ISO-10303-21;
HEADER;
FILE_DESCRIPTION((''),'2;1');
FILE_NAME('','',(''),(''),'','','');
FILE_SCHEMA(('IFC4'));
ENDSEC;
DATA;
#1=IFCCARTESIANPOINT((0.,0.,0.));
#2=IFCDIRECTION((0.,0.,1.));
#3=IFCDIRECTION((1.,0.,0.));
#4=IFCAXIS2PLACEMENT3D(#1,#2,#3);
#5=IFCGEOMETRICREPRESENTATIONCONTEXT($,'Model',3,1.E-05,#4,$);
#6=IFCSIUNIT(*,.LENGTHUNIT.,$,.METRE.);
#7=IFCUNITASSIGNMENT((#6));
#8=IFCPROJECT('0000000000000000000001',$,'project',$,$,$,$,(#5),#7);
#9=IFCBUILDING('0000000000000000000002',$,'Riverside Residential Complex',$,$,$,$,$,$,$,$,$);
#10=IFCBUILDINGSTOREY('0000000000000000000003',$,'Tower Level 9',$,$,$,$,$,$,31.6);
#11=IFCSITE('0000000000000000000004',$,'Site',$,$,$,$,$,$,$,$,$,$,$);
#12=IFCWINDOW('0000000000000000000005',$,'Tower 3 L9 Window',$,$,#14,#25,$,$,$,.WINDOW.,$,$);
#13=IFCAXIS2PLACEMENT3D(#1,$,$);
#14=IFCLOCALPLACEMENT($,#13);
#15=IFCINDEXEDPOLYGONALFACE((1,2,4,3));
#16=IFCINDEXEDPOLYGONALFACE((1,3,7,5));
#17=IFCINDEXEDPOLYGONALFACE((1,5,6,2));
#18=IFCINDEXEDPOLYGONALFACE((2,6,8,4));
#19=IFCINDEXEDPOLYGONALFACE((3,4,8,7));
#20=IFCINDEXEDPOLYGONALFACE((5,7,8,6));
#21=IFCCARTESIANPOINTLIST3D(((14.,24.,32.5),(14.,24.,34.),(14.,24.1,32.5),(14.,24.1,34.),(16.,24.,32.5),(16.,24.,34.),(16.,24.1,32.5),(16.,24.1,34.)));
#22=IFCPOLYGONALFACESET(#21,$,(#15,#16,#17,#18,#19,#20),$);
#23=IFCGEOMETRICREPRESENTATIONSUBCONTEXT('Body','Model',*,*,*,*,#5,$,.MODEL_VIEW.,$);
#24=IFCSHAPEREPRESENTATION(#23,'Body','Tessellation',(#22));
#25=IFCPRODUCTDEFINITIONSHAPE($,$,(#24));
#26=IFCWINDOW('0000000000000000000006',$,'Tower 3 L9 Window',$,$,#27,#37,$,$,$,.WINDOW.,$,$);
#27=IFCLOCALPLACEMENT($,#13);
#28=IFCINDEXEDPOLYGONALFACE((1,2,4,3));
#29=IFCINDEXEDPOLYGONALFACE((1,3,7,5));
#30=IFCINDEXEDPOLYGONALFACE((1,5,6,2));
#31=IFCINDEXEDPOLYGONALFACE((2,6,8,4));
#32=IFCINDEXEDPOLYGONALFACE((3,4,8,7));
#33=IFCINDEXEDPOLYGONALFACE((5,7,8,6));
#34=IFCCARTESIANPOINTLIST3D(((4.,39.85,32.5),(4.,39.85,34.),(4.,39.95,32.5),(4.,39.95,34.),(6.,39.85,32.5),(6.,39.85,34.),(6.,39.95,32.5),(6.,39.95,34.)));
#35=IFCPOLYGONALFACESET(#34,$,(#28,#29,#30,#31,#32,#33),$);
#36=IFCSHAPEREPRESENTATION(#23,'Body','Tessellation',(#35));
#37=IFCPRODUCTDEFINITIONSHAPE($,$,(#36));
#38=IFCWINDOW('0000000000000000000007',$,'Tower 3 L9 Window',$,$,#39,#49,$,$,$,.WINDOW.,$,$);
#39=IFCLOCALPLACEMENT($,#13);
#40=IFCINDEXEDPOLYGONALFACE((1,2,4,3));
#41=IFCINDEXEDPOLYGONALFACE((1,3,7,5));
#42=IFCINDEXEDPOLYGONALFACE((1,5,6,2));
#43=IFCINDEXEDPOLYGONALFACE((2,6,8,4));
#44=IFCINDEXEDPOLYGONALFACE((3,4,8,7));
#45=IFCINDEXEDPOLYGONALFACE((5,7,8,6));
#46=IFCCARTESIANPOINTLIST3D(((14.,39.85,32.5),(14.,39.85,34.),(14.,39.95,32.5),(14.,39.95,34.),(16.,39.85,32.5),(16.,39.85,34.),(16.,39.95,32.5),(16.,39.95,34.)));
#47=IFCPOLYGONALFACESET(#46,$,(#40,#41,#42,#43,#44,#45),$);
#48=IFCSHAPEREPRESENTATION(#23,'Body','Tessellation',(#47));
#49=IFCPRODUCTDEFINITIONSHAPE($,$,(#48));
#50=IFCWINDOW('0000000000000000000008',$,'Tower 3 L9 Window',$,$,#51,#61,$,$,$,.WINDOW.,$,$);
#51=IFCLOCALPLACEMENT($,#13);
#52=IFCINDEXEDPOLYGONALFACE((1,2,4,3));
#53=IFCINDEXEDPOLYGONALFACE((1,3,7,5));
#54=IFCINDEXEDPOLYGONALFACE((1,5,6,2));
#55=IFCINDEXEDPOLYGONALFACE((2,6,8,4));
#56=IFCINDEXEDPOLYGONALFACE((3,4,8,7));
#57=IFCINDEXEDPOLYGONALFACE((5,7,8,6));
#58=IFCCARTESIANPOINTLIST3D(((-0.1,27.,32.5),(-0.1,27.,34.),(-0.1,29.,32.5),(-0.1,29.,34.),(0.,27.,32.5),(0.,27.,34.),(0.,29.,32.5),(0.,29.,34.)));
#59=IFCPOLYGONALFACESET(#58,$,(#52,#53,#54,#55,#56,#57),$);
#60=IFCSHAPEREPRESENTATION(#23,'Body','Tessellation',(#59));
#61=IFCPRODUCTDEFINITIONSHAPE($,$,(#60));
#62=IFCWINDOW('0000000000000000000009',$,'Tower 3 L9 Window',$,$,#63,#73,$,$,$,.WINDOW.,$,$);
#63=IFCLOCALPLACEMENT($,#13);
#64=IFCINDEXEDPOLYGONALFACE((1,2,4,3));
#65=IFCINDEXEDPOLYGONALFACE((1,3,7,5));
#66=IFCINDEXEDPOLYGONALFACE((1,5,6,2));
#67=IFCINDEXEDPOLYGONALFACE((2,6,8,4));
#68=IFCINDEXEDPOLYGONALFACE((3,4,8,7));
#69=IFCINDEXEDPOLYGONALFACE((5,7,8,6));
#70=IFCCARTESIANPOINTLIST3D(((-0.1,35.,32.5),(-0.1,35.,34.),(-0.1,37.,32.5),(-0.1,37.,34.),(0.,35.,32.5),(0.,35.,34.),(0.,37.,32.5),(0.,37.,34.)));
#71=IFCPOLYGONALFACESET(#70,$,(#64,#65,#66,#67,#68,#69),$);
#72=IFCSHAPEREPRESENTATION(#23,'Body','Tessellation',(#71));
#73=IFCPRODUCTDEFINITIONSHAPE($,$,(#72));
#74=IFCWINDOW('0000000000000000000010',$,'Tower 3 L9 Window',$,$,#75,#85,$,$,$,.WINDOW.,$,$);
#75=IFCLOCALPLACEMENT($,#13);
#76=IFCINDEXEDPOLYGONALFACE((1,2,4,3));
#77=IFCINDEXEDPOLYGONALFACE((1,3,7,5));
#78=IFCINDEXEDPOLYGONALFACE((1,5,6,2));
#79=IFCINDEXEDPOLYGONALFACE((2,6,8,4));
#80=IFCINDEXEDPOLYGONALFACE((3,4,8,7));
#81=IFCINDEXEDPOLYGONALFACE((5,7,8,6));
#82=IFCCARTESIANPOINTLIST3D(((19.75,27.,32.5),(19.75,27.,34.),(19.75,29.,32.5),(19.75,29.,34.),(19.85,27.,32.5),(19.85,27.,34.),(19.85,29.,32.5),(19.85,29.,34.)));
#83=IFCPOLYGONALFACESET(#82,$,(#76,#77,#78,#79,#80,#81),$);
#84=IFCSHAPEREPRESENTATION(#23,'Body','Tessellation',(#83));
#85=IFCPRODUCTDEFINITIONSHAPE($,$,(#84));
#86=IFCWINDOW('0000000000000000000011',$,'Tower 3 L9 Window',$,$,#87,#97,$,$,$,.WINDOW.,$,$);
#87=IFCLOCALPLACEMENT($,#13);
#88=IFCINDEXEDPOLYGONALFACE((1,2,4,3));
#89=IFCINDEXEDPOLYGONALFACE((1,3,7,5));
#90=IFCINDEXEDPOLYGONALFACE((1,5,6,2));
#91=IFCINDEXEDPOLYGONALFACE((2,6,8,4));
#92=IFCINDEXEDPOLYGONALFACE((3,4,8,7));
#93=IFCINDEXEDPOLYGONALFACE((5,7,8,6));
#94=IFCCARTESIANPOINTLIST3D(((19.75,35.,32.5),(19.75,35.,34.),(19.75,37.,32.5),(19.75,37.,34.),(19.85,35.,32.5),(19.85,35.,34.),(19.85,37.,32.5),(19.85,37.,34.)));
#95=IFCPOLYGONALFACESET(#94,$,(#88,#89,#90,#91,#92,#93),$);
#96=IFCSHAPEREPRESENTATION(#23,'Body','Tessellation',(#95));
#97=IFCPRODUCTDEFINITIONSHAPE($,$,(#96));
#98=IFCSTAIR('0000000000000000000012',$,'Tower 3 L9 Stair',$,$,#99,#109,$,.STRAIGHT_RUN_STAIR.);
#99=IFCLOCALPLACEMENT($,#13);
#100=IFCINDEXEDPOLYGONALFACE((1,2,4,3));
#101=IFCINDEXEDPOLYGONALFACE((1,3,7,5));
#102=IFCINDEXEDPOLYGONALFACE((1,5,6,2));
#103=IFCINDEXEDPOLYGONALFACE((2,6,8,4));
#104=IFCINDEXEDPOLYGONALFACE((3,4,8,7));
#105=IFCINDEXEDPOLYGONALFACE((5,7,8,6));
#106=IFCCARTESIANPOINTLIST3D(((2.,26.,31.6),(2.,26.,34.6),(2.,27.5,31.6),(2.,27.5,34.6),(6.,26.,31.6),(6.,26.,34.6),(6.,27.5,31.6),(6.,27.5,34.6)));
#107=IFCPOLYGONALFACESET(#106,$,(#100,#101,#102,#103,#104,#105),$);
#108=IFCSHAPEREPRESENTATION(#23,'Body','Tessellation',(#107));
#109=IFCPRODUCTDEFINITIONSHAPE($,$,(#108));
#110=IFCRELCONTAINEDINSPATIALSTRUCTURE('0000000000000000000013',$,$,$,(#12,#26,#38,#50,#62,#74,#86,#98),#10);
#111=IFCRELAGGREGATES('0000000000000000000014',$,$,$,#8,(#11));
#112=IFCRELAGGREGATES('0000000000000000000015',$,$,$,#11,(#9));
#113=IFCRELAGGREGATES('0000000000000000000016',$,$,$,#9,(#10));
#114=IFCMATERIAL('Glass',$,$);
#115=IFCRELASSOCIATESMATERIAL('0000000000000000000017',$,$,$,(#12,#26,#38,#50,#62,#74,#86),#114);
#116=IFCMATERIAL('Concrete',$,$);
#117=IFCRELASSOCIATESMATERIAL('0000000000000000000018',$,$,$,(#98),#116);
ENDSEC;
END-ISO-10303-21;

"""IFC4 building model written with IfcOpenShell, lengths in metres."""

from ifc_helpers import new_model, si_unit, frame, origin_with_axes, place, context, subcontext, project, spatial, line, indexed_curve, outline, extrude, material, element, save


model = new_model("IFC4")

# Units and contexts
model_context = context("Model", 3, precision=1e-05, world=origin_with_axes())
body_context = subcontext(model_context, "Body", "Model", "MODEL_VIEW")
ifc_project = project(units=[si_unit("LENGTHUNIT", "METRE")], contexts=[model_context])

# Site, building, storey
site = spatial("IfcSite", under=ifc_project, Name="Site")
building = spatial("IfcBuilding", under=site, Name="Riverside Residential Complex")
storey = spatial("IfcBuildingStorey", under=building, Name="Tower Level 9", Elevation=31.6)

# Shared definitions
ifc_material_1 = material(Name="Concrete")

# Windows
ifc_material_2 = material(Name="Glass")
for number, where, z_axis, x_axis, name in (
    (1, (14.0, 24.0, 32.5), (0.0, 0.0, 1.0), (1.0, 0.0, 0.0), "Tower 3 L9 Window"),
    (2, (4.0, 39.85, 32.5), (0.0, 0.0, 1.0), (1.0, 0.0, 0.0), "Tower 3 L9 Window"),
    (3, (14.0, 39.85, 32.5), (0.0, 0.0, 1.0), (1.0, 0.0, 0.0), "Tower 3 L9 Window"),
    (4, (0.0, 27.0, 32.5), (0.0, 0.0, 1.0), (0.0, 1.0, 0.0), "Tower 3 L9 Window"),
    (5, (0.0, 35.0, 32.5), (0.0, 0.0, 1.0), (0.0, 1.0, 0.0), "Tower 3 L9 Window"),
    (6, (19.85, 27.0, 32.5), (0.0, 0.0, 1.0), (0.0, 1.0, 0.0), "Tower 3 L9 Window"),
    (7, (19.85, 35.0, 32.5), (0.0, 0.0, 1.0), (0.0, 1.0, 0.0), "Tower 3 L9 Window"),
):
    element("IfcWindow", number, at=place(None, frame(where, z_axis=z_axis, x_axis=x_axis)), inside=storey, material=ifc_material_2, Name=name, PredefinedType="WINDOW", context=body_context, shape_type="SweptSolid", body=[
        extrude(outline(indexed_curve([(0.0, 0.0), (2.0, 0.0), (2.0, 0.1), (0.0, 0.1)], segments=[line(1, 2, 3, 4, 1)])), origin_with_axes(), (0.0, 0.0, 1.0), 1.5),
    ])

# Stair
stair_placement = place(None, frame((2.0, 26.0, 31.6), z_axis=(0.0, 0.0, 1.0), x_axis=(1.0, 0.0, 0.0)))
element("IfcStair", 8, at=stair_placement, inside=storey, material=ifc_material_1, Name="Tower 3 L9 Stair", PredefinedType="STRAIGHT_RUN_STAIR", context=body_context, shape_type="SweptSolid", body=[
    extrude(outline(indexed_curve([(0.0, 0.0), (4.0, 0.0), (4.0, 1.5), (0.0, 1.5)], segments=[line(1, 2, 3, 4, 1)])), origin_with_axes(), (0.0, 0.0, 1.0), 3.0),
])

save(model, "model.ifc")
